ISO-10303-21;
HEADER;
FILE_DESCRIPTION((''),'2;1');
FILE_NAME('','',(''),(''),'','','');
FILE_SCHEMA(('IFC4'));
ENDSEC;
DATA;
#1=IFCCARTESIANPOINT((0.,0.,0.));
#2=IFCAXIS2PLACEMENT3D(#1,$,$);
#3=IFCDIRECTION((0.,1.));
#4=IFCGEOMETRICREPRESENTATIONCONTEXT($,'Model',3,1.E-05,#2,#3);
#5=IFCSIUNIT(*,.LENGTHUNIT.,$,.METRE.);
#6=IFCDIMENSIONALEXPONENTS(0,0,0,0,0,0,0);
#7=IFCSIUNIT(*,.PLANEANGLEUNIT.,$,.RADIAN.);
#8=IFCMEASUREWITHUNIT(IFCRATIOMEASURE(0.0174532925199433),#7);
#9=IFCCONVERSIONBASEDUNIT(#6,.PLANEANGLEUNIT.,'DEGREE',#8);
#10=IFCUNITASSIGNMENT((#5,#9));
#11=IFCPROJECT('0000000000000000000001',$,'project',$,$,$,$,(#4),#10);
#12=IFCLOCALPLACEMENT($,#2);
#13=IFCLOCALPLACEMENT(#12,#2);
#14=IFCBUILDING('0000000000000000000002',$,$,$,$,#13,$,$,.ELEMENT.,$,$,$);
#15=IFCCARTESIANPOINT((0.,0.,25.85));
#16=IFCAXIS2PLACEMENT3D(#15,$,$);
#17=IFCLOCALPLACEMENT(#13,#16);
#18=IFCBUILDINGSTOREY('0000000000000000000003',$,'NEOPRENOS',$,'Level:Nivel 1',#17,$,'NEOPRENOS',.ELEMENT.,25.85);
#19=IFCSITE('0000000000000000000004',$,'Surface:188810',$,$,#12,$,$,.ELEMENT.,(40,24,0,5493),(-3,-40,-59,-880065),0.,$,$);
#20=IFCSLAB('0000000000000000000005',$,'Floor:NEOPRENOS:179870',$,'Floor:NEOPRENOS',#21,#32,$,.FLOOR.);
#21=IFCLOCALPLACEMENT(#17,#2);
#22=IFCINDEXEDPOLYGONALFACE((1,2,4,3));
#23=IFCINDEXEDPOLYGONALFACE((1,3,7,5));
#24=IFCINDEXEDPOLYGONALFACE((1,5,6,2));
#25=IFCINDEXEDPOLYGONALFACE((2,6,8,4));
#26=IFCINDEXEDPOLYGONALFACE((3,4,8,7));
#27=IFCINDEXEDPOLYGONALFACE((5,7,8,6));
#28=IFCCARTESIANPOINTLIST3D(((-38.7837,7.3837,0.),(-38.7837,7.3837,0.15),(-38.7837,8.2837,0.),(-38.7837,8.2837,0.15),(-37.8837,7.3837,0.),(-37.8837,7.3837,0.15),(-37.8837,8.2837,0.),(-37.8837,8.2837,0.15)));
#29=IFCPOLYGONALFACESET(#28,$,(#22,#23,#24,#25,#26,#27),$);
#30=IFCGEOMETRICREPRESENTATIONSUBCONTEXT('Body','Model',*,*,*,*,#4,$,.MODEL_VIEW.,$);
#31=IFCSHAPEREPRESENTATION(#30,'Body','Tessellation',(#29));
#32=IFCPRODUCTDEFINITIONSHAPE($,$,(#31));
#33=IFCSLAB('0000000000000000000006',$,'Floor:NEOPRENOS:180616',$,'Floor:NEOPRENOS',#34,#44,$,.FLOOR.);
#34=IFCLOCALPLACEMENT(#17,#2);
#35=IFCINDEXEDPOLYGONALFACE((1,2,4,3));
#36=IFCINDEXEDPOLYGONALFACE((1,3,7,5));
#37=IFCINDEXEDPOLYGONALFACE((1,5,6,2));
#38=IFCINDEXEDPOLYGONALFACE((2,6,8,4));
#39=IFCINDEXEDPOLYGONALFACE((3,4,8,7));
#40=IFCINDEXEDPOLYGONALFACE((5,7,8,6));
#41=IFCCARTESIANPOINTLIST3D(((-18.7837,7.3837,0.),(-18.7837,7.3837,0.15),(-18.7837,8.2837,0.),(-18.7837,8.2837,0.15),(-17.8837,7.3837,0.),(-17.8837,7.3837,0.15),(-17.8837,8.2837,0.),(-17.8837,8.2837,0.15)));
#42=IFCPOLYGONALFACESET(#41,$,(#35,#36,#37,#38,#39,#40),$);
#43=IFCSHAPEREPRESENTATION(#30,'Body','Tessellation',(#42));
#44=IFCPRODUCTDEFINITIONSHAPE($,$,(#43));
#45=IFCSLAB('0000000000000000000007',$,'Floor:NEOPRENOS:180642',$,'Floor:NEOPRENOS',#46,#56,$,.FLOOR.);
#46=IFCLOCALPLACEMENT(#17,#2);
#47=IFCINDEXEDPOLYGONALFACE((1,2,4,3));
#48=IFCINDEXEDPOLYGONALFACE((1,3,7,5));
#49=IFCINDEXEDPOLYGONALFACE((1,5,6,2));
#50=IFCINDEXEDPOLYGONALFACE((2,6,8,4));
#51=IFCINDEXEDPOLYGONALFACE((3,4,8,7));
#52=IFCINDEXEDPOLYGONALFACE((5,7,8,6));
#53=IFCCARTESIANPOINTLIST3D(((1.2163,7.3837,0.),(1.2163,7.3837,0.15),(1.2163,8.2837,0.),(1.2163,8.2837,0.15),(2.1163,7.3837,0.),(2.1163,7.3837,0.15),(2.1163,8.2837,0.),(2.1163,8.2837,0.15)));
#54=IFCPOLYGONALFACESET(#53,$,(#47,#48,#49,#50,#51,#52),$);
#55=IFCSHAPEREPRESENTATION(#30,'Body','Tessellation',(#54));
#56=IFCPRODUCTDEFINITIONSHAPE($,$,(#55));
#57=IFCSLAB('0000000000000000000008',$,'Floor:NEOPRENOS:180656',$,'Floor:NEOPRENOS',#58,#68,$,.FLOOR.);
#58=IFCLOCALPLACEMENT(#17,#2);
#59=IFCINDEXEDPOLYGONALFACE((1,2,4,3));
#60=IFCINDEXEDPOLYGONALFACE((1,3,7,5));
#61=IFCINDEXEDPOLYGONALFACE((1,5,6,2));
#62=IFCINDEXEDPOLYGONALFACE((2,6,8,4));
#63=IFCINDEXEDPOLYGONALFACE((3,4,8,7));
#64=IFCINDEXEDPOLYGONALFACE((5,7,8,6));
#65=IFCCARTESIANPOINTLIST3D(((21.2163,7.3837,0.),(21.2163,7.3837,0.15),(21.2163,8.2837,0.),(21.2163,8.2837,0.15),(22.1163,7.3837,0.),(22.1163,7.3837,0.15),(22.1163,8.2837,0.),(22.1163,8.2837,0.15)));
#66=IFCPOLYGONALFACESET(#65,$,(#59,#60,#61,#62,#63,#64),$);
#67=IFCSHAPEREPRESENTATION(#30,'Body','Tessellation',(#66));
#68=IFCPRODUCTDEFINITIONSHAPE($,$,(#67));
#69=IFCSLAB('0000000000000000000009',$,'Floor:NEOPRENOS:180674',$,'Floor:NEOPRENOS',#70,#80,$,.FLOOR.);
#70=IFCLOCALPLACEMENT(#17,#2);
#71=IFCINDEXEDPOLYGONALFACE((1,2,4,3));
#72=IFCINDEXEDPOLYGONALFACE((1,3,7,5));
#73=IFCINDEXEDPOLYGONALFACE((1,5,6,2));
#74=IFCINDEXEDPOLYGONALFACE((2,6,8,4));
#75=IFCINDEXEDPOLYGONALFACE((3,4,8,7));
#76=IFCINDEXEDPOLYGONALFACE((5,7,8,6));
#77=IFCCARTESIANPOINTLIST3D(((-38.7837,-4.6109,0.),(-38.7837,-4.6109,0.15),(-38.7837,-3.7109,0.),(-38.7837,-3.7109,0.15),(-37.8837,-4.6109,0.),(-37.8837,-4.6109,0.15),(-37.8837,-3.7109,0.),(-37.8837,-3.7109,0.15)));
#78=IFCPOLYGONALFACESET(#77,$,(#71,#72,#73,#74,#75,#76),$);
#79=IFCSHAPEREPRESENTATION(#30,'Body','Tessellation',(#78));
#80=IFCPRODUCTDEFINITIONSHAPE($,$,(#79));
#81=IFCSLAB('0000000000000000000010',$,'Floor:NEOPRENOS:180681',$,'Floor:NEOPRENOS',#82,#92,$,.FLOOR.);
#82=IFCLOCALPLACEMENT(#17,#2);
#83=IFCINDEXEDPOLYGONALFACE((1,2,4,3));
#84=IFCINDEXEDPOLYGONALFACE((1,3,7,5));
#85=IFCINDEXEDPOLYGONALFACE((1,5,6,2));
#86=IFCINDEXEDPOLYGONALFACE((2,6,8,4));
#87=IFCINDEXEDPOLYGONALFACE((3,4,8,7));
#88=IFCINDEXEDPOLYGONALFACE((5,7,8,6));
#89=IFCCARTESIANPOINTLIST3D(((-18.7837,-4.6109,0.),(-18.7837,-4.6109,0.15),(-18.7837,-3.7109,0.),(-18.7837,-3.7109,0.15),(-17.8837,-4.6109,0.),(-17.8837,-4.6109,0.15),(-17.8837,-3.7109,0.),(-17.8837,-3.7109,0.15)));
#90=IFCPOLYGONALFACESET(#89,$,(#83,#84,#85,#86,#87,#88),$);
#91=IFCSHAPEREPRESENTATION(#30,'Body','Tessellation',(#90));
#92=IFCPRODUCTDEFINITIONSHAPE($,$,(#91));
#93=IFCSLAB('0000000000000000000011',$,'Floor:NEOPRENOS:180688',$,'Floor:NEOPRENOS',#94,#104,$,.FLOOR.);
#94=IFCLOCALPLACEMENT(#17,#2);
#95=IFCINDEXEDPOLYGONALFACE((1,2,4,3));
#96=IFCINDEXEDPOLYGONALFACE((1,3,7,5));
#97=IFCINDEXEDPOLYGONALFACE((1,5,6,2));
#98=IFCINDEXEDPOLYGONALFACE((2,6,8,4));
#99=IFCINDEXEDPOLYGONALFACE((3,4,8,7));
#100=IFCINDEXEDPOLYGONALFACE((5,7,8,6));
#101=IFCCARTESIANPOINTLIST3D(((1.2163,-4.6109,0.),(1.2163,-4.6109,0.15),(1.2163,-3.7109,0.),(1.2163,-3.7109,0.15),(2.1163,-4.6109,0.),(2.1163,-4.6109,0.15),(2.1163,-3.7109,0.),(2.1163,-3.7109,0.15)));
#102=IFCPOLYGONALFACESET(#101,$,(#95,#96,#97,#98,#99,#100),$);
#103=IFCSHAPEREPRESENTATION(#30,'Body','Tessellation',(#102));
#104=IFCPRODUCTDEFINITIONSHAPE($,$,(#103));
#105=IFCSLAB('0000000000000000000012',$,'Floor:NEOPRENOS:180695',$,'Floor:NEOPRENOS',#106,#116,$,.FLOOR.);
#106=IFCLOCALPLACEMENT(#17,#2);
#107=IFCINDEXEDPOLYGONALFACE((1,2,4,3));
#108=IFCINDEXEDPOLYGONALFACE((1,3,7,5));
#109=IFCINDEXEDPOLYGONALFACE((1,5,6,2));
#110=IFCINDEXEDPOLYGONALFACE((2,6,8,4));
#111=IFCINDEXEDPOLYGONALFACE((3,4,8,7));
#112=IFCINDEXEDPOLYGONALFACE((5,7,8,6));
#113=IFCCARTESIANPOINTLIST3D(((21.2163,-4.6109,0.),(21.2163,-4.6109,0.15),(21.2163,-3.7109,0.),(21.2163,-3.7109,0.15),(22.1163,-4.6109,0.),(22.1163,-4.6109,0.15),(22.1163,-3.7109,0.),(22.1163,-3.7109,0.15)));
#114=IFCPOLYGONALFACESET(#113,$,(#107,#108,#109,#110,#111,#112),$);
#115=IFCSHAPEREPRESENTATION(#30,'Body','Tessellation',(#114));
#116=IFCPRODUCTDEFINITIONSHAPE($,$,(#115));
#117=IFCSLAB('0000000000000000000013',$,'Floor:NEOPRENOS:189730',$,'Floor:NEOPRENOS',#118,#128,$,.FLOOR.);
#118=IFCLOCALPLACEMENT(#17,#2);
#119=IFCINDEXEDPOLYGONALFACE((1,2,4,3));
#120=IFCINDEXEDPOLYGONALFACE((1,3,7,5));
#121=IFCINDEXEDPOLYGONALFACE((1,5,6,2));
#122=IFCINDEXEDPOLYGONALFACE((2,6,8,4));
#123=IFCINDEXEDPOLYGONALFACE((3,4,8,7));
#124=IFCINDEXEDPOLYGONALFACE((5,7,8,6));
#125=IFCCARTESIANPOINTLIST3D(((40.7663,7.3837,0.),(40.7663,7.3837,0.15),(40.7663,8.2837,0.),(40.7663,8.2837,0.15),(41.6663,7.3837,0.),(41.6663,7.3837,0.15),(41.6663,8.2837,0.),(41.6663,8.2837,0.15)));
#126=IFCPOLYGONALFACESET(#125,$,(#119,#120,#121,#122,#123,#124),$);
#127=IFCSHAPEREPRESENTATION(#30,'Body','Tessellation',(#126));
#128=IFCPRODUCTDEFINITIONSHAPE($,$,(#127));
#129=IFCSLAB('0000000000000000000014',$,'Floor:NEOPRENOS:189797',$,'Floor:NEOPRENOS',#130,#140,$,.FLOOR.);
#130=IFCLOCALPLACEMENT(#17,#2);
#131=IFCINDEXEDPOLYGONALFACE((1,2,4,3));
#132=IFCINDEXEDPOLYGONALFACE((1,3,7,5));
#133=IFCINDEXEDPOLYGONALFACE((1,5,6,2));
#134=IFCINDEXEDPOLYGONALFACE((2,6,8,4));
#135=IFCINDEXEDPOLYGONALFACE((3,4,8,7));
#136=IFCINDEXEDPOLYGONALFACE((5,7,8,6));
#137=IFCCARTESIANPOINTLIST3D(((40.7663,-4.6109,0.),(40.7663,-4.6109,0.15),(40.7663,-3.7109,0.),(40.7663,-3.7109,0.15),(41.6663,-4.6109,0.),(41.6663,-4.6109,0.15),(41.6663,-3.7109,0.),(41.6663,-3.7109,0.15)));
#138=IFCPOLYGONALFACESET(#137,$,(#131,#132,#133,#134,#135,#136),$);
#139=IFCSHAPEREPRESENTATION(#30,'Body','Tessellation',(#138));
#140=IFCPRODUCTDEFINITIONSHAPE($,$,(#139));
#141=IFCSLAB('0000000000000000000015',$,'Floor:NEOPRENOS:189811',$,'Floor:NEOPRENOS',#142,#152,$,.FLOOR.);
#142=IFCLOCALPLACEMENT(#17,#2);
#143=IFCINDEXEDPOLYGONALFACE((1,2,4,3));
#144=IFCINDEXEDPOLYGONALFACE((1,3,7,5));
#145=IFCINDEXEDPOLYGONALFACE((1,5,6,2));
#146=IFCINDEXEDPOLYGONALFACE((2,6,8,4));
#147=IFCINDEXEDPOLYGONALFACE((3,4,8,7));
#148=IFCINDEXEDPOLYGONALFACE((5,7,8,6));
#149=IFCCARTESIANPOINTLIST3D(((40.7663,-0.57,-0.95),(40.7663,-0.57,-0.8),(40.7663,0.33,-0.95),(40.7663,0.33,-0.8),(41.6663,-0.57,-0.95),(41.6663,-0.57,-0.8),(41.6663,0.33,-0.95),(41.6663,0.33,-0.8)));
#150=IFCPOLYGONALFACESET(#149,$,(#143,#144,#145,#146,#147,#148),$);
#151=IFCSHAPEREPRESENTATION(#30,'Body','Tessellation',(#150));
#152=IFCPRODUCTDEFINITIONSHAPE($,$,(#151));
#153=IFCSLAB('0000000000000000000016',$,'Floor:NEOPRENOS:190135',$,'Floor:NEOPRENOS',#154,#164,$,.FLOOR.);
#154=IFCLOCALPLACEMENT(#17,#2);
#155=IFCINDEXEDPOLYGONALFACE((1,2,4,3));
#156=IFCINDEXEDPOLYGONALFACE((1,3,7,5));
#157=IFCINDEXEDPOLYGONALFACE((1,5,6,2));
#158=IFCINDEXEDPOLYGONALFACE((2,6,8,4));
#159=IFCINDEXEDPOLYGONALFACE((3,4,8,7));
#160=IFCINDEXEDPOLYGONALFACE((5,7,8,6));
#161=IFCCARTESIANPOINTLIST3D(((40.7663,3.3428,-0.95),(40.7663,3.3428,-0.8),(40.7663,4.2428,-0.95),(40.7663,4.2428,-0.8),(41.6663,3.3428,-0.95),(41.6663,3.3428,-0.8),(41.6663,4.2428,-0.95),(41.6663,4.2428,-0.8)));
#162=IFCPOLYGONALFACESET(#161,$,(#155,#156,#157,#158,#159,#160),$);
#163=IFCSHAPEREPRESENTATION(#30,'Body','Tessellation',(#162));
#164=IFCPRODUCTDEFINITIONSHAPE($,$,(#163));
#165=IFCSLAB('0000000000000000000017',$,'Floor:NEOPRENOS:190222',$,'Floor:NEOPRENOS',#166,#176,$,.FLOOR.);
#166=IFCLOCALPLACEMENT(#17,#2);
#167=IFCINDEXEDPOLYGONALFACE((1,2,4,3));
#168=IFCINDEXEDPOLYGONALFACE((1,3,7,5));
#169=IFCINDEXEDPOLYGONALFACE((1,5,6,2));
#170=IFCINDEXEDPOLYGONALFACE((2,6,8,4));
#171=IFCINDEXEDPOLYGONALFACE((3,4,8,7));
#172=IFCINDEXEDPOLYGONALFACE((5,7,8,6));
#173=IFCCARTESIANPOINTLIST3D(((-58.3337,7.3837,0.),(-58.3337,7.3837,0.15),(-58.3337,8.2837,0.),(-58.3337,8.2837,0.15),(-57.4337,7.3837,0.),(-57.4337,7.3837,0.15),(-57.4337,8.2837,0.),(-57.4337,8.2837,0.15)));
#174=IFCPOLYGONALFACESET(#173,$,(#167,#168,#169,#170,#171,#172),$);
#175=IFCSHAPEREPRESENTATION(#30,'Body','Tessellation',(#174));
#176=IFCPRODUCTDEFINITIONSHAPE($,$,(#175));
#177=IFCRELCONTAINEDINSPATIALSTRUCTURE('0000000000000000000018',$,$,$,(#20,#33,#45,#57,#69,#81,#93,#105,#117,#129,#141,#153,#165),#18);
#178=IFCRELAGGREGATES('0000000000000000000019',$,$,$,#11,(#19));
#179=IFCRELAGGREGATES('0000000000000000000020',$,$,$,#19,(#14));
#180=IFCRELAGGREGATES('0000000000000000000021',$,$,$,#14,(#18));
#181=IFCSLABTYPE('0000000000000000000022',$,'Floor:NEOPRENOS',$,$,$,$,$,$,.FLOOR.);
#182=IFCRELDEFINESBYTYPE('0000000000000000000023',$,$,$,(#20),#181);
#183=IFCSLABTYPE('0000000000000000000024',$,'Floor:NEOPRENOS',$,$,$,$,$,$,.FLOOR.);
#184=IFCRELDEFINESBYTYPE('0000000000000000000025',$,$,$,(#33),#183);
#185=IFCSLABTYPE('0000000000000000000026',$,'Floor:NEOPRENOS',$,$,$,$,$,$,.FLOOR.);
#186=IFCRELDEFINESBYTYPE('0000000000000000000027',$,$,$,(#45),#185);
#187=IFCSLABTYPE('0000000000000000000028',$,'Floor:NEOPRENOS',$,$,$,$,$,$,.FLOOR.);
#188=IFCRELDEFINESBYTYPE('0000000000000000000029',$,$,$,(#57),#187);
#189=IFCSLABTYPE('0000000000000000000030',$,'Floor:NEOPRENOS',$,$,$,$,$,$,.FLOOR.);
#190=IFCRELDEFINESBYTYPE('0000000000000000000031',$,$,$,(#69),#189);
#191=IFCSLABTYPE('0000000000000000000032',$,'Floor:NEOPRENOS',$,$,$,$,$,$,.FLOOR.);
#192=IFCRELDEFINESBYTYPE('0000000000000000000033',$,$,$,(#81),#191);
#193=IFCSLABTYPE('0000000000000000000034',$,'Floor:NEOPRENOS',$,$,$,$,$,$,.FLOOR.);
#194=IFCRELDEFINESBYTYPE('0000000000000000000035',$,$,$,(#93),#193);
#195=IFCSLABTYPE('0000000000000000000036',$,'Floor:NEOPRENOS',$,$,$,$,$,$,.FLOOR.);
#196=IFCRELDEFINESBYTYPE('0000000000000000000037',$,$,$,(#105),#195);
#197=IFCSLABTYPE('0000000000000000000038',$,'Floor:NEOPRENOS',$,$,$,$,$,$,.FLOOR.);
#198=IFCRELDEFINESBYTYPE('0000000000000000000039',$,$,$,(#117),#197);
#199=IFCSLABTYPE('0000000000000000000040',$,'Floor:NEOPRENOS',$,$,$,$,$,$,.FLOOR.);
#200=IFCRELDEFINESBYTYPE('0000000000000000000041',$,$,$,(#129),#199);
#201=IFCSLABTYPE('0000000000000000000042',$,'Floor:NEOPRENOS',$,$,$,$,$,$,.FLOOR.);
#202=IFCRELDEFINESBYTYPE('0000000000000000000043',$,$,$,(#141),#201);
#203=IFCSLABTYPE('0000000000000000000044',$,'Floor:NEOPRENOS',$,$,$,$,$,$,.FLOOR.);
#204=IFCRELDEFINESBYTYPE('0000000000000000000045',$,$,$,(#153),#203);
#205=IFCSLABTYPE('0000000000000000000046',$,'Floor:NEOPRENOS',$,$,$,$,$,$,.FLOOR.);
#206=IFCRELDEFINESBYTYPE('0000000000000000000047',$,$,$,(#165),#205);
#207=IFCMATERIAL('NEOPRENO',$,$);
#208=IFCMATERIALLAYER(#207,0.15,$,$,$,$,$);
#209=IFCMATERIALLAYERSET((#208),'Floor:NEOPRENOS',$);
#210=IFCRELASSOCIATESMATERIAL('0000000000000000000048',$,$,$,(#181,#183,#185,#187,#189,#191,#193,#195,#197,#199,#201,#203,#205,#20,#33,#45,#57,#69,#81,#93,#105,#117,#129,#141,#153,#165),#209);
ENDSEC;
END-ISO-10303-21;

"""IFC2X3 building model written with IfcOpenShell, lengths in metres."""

from ifc_helpers import new_model, entity, si_unit, converted_unit, direction, frame, frame_2d, origin, origin_2d_with_axis, place, context, subcontext, project, spatial, rectangle, extrude, material, layer, layer_set, layer_usage, type_object, element, save


model = new_model("IFC2X3")

# Units and contexts
model_context = context("Model", 3, precision=1e-05, world=origin(), true_north=direction((0.0, 1.0)))
body_context = subcontext(model_context, "Body", "Model", "MODEL_VIEW")
ifc_project = project(units=[si_unit("LENGTHUNIT", "METRE"), converted_unit("PLANEANGLEUNIT", "DEGREE", entity("IfcRatioMeasure", 0.0174532925199433), si_unit("PLANEANGLEUNIT", "RADIAN"), dimensions=[0, 0, 0, 0, 0, 0, 0])], contexts=[model_context])

# Site, building, storey
site_placement = place(None, origin())
site = spatial("IfcSite", under=ifc_project, at=site_placement, Name="Surface:188810", CompositionType="ELEMENT", RefLatitude=(40, 24, 0, 5493), RefLongitude=(-3, -40, -59, -880065), RefElevation=0.0)
building_placement = place(site_placement, origin())
building = spatial("IfcBuilding", under=site, at=building_placement, CompositionType="ELEMENT")
storey_placement = place(building_placement, frame((0.0, 0.0, 25.85)))
storey = spatial("IfcBuildingStorey", under=building, at=storey_placement, Name="NEOPRENOS", ObjectType="Level:Nivel 1", LongName="NEOPRENOS", CompositionType="ELEMENT", Elevation=25.85)

# Slabs
ifc_material_1 = material(Name="NEOPRENO")
ifc_layer = layer(ifc_material_1, 0.15)
ifc_layer_set = layer_set([ifc_layer], Name="Floor:NEOPRENOS")
ifc_layer_usage_1 = layer_usage(ifc_layer_set, "AXIS3", "POSITIVE", 0.0)
slab_type_1 = type_object("IfcSlabType", Name="Floor:NEOPRENOS", PredefinedType="FLOOR", material=ifc_layer_set)
slab_1_placement = place(storey_placement, origin())
element("IfcSlab", 1, at=slab_1_placement, inside=storey, type_object=slab_type_1, material=ifc_layer_usage_1, Name="Floor:NEOPRENOS:179870", ObjectType="Floor:NEOPRENOS", PredefinedType="FLOOR", context=body_context, shape_type="SweptSolid", body=[
    extrude(rectangle(XDim=0.9, YDim=0.9, at=frame_2d((0.0, 0.0), x_axis=(1.0, 0.0))), frame((-38.3337, 7.8337, 0.15), z_axis=(0.0, 0.0, -1.0), x_axis=(0.0, 1.0, 0.0)), (0.0, 0.0, 1.0), 0.15),
])
ifc_layer_usage_2 = layer_usage(ifc_layer_set, "AXIS3", "POSITIVE", 0.0)
slab_type_2 = type_object("IfcSlabType", Name="Floor:NEOPRENOS", PredefinedType="FLOOR", material=ifc_layer_set)
slab_2_placement = place(storey_placement, origin())
element("IfcSlab", 2, at=slab_2_placement, inside=storey, type_object=slab_type_2, material=ifc_layer_usage_2, Name="Floor:NEOPRENOS:180616", ObjectType="Floor:NEOPRENOS", PredefinedType="FLOOR", context=body_context, shape_type="SweptSolid", body=[
    extrude(rectangle(XDim=0.9, YDim=0.9, at=frame_2d((0.0, 0.0), x_axis=(1.0, 0.0))), frame((-18.3337, 7.8337, 0.15), z_axis=(0.0, 0.0, -1.0), x_axis=(0.0, 1.0, 0.0)), (0.0, 0.0, 1.0), 0.15),
])
ifc_layer_usage_3 = layer_usage(ifc_layer_set, "AXIS3", "POSITIVE", 0.0)
slab_type_3 = type_object("IfcSlabType", Name="Floor:NEOPRENOS", PredefinedType="FLOOR", material=ifc_layer_set)
slab_3_placement = place(storey_placement, origin())
element("IfcSlab", 3, at=slab_3_placement, inside=storey, type_object=slab_type_3, material=ifc_layer_usage_3, Name="Floor:NEOPRENOS:180642", ObjectType="Floor:NEOPRENOS", PredefinedType="FLOOR", context=body_context, shape_type="SweptSolid", body=[
    extrude(rectangle(XDim=0.9, YDim=0.9, at=frame_2d((0.0, 0.0), x_axis=(1.0, 0.0))), frame((1.6663, 7.8337, 0.15), z_axis=(0.0, 0.0, -1.0), x_axis=(0.0, 1.0, 0.0)), (0.0, 0.0, 1.0), 0.15),
])
ifc_layer_usage_4 = layer_usage(ifc_layer_set, "AXIS3", "POSITIVE", 0.0)
slab_type_4 = type_object("IfcSlabType", Name="Floor:NEOPRENOS", PredefinedType="FLOOR", material=ifc_layer_set)
slab_4_placement = place(storey_placement, origin())
element("IfcSlab", 4, at=slab_4_placement, inside=storey, type_object=slab_type_4, material=ifc_layer_usage_4, Name="Floor:NEOPRENOS:180656", ObjectType="Floor:NEOPRENOS", PredefinedType="FLOOR", context=body_context, shape_type="SweptSolid", body=[
    extrude(rectangle(XDim=0.9, YDim=0.9, at=frame_2d((0.0, 0.0), x_axis=(1.0, 0.0))), frame((21.6663, 7.8337, 0.15), z_axis=(0.0, 0.0, -1.0), x_axis=(0.0, 1.0, 0.0)), (0.0, 0.0, 1.0), 0.15),
])
ifc_layer_usage_5 = layer_usage(ifc_layer_set, "AXIS3", "POSITIVE", 0.0)
slab_type_5 = type_object("IfcSlabType", Name="Floor:NEOPRENOS", PredefinedType="FLOOR", material=ifc_layer_set)
slab_5_placement = place(storey_placement, origin())
element("IfcSlab", 5, at=slab_5_placement, inside=storey, type_object=slab_type_5, material=ifc_layer_usage_5, Name="Floor:NEOPRENOS:180674", ObjectType="Floor:NEOPRENOS", PredefinedType="FLOOR", context=body_context, shape_type="SweptSolid", body=[
    extrude(rectangle(XDim=0.9, YDim=0.9, at=origin_2d_with_axis()), frame((-38.3337, -4.1609, 0.15), z_axis=(0.0, 0.0, -1.0), x_axis=(0.0, 1.0, 0.0)), (0.0, 0.0, 1.0), 0.15),
])
ifc_layer_usage_6 = layer_usage(ifc_layer_set, "AXIS3", "POSITIVE", 0.0)
slab_type_6 = type_object("IfcSlabType", Name="Floor:NEOPRENOS", PredefinedType="FLOOR", material=ifc_layer_set)
slab_6_placement = place(storey_placement, origin())
element("IfcSlab", 6, at=slab_6_placement, inside=storey, type_object=slab_type_6, material=ifc_layer_usage_6, Name="Floor:NEOPRENOS:180681", ObjectType="Floor:NEOPRENOS", PredefinedType="FLOOR", context=body_context, shape_type="SweptSolid", body=[
    extrude(rectangle(XDim=0.9, YDim=0.9, at=frame_2d((0.0, 0.0), x_axis=(1.0, 0.0))), frame((-18.3337, -4.1609, 0.15), z_axis=(0.0, 0.0, -1.0), x_axis=(0.0, 1.0, 0.0)), (0.0, 0.0, 1.0), 0.15),
])
ifc_layer_usage_7 = layer_usage(ifc_layer_set, "AXIS3", "POSITIVE", 0.0)
slab_type_7 = type_object("IfcSlabType", Name="Floor:NEOPRENOS", PredefinedType="FLOOR", material=ifc_layer_set)
slab_7_placement = place(storey_placement, origin())
element("IfcSlab", 7, at=slab_7_placement, inside=storey, type_object=slab_type_7, material=ifc_layer_usage_7, Name="Floor:NEOPRENOS:180688", ObjectType="Floor:NEOPRENOS", PredefinedType="FLOOR", context=body_context, shape_type="SweptSolid", body=[
    extrude(rectangle(XDim=0.9, YDim=0.9, at=origin_2d_with_axis()), frame((1.6663, -4.1609, 0.15), z_axis=(0.0, 0.0, -1.0), x_axis=(0.0, 1.0, 0.0)), (0.0, 0.0, 1.0), 0.15),
])
ifc_layer_usage_8 = layer_usage(ifc_layer_set, "AXIS3", "POSITIVE", 0.0)
slab_type_8 = type_object("IfcSlabType", Name="Floor:NEOPRENOS", PredefinedType="FLOOR", material=ifc_layer_set)
slab_8_placement = place(storey_placement, origin())
element("IfcSlab", 8, at=slab_8_placement, inside=storey, type_object=slab_type_8, material=ifc_layer_usage_8, Name="Floor:NEOPRENOS:180695", ObjectType="Floor:NEOPRENOS", PredefinedType="FLOOR", context=body_context, shape_type="SweptSolid", body=[
    extrude(rectangle(XDim=0.9, YDim=0.9, at=frame_2d((0.0, 0.0), x_axis=(1.0, 0.0))), frame((21.6663, -4.1609, 0.15), z_axis=(0.0, 0.0, -1.0), x_axis=(0.0, 1.0, 0.0)), (0.0, 0.0, 1.0), 0.15),
])
ifc_layer_usage_9 = layer_usage(ifc_layer_set, "AXIS3", "POSITIVE", 0.0)
slab_type_9 = type_object("IfcSlabType", Name="Floor:NEOPRENOS", PredefinedType="FLOOR", material=ifc_layer_set)
slab_9_placement = place(storey_placement, origin())
element("IfcSlab", 9, at=slab_9_placement, inside=storey, type_object=slab_type_9, material=ifc_layer_usage_9, Name="Floor:NEOPRENOS:189730", ObjectType="Floor:NEOPRENOS", PredefinedType="FLOOR", context=body_context, shape_type="SweptSolid", body=[
    extrude(rectangle(XDim=0.9, YDim=0.9, at=frame_2d((0.0, 0.0), x_axis=(1.0, 0.0))), frame((41.2163, 7.8337, 0.15), z_axis=(0.0, 0.0, -1.0), x_axis=(0.0, 1.0, 0.0)), (0.0, 0.0, 1.0), 0.15),
])
ifc_layer_usage_10 = layer_usage(ifc_layer_set, "AXIS3", "POSITIVE", 0.0)
slab_type_10 = type_object("IfcSlabType", Name="Floor:NEOPRENOS", PredefinedType="FLOOR", material=ifc_layer_set)
slab_10_placement = place(storey_placement, origin())
element("IfcSlab", 10, at=slab_10_placement, inside=storey, type_object=slab_type_10, material=ifc_layer_usage_10, Name="Floor:NEOPRENOS:189797", ObjectType="Floor:NEOPRENOS", PredefinedType="FLOOR", context=body_context, shape_type="SweptSolid", body=[
    extrude(rectangle(XDim=0.9, YDim=0.9, at=frame_2d((0.0, 0.0), x_axis=(1.0, 0.0))), frame((41.2163, -4.1609, 0.15), z_axis=(0.0, 0.0, -1.0), x_axis=(0.0, 1.0, 0.0)), (0.0, 0.0, 1.0), 0.15),
])
ifc_layer_usage_11 = layer_usage(ifc_layer_set, "AXIS3", "POSITIVE", 0.0)
slab_type_11 = type_object("IfcSlabType", Name="Floor:NEOPRENOS", PredefinedType="FLOOR", material=ifc_layer_set)
slab_11_placement = place(storey_placement, origin())
element("IfcSlab", 11, at=slab_11_placement, inside=storey, type_object=slab_type_11, material=ifc_layer_usage_11, Name="Floor:NEOPRENOS:189811", ObjectType="Floor:NEOPRENOS", PredefinedType="FLOOR", context=body_context, shape_type="SweptSolid", body=[
    extrude(rectangle(XDim=0.9, YDim=0.9, at=frame_2d((0.0, 0.0), x_axis=(1.0, 0.0))), frame((41.2163, -0.12, -0.8), z_axis=(0.0, 0.0, -1.0), x_axis=(0.0, 1.0, 0.0)), (0.0, 0.0, 1.0), 0.15),
])
ifc_layer_usage_12 = layer_usage(ifc_layer_set, "AXIS3", "POSITIVE", 0.0)
slab_type_12 = type_object("IfcSlabType", Name="Floor:NEOPRENOS", PredefinedType="FLOOR", material=ifc_layer_set)
slab_12_placement = place(storey_placement, origin())
element("IfcSlab", 12, at=slab_12_placement, inside=storey, type_object=slab_type_12, material=ifc_layer_usage_12, Name="Floor:NEOPRENOS:190135", ObjectType="Floor:NEOPRENOS", PredefinedType="FLOOR", context=body_context, shape_type="SweptSolid", body=[
    extrude(rectangle(XDim=0.9, YDim=0.9, at=origin_2d_with_axis()), frame((41.2163, 3.7928, -0.8), z_axis=(0.0, 0.0, -1.0), x_axis=(0.0, 1.0, 0.0)), (0.0, 0.0, 1.0), 0.15),
])
ifc_layer_usage_13 = layer_usage(ifc_layer_set, "AXIS3", "POSITIVE", 0.0)
slab_type_13 = type_object("IfcSlabType", Name="Floor:NEOPRENOS", PredefinedType="FLOOR", material=ifc_layer_set)
slab_13_placement = place(storey_placement, origin())
element("IfcSlab", 13, at=slab_13_placement, inside=storey, type_object=slab_type_13, material=ifc_layer_usage_13, Name="Floor:NEOPRENOS:190222", ObjectType="Floor:NEOPRENOS", PredefinedType="FLOOR", context=body_context, shape_type="SweptSolid", body=[
    extrude(rectangle(XDim=0.9, YDim=0.9, at=frame_2d((0.0, 0.0), x_axis=(1.0, 0.0))), frame((-57.8837, 7.8337, 0.15), z_axis=(0.0, 0.0, -1.0), x_axis=(0.0, 1.0, 0.0)), (0.0, 0.0, 1.0), 0.15),
])

save(model, "model.ifc")
